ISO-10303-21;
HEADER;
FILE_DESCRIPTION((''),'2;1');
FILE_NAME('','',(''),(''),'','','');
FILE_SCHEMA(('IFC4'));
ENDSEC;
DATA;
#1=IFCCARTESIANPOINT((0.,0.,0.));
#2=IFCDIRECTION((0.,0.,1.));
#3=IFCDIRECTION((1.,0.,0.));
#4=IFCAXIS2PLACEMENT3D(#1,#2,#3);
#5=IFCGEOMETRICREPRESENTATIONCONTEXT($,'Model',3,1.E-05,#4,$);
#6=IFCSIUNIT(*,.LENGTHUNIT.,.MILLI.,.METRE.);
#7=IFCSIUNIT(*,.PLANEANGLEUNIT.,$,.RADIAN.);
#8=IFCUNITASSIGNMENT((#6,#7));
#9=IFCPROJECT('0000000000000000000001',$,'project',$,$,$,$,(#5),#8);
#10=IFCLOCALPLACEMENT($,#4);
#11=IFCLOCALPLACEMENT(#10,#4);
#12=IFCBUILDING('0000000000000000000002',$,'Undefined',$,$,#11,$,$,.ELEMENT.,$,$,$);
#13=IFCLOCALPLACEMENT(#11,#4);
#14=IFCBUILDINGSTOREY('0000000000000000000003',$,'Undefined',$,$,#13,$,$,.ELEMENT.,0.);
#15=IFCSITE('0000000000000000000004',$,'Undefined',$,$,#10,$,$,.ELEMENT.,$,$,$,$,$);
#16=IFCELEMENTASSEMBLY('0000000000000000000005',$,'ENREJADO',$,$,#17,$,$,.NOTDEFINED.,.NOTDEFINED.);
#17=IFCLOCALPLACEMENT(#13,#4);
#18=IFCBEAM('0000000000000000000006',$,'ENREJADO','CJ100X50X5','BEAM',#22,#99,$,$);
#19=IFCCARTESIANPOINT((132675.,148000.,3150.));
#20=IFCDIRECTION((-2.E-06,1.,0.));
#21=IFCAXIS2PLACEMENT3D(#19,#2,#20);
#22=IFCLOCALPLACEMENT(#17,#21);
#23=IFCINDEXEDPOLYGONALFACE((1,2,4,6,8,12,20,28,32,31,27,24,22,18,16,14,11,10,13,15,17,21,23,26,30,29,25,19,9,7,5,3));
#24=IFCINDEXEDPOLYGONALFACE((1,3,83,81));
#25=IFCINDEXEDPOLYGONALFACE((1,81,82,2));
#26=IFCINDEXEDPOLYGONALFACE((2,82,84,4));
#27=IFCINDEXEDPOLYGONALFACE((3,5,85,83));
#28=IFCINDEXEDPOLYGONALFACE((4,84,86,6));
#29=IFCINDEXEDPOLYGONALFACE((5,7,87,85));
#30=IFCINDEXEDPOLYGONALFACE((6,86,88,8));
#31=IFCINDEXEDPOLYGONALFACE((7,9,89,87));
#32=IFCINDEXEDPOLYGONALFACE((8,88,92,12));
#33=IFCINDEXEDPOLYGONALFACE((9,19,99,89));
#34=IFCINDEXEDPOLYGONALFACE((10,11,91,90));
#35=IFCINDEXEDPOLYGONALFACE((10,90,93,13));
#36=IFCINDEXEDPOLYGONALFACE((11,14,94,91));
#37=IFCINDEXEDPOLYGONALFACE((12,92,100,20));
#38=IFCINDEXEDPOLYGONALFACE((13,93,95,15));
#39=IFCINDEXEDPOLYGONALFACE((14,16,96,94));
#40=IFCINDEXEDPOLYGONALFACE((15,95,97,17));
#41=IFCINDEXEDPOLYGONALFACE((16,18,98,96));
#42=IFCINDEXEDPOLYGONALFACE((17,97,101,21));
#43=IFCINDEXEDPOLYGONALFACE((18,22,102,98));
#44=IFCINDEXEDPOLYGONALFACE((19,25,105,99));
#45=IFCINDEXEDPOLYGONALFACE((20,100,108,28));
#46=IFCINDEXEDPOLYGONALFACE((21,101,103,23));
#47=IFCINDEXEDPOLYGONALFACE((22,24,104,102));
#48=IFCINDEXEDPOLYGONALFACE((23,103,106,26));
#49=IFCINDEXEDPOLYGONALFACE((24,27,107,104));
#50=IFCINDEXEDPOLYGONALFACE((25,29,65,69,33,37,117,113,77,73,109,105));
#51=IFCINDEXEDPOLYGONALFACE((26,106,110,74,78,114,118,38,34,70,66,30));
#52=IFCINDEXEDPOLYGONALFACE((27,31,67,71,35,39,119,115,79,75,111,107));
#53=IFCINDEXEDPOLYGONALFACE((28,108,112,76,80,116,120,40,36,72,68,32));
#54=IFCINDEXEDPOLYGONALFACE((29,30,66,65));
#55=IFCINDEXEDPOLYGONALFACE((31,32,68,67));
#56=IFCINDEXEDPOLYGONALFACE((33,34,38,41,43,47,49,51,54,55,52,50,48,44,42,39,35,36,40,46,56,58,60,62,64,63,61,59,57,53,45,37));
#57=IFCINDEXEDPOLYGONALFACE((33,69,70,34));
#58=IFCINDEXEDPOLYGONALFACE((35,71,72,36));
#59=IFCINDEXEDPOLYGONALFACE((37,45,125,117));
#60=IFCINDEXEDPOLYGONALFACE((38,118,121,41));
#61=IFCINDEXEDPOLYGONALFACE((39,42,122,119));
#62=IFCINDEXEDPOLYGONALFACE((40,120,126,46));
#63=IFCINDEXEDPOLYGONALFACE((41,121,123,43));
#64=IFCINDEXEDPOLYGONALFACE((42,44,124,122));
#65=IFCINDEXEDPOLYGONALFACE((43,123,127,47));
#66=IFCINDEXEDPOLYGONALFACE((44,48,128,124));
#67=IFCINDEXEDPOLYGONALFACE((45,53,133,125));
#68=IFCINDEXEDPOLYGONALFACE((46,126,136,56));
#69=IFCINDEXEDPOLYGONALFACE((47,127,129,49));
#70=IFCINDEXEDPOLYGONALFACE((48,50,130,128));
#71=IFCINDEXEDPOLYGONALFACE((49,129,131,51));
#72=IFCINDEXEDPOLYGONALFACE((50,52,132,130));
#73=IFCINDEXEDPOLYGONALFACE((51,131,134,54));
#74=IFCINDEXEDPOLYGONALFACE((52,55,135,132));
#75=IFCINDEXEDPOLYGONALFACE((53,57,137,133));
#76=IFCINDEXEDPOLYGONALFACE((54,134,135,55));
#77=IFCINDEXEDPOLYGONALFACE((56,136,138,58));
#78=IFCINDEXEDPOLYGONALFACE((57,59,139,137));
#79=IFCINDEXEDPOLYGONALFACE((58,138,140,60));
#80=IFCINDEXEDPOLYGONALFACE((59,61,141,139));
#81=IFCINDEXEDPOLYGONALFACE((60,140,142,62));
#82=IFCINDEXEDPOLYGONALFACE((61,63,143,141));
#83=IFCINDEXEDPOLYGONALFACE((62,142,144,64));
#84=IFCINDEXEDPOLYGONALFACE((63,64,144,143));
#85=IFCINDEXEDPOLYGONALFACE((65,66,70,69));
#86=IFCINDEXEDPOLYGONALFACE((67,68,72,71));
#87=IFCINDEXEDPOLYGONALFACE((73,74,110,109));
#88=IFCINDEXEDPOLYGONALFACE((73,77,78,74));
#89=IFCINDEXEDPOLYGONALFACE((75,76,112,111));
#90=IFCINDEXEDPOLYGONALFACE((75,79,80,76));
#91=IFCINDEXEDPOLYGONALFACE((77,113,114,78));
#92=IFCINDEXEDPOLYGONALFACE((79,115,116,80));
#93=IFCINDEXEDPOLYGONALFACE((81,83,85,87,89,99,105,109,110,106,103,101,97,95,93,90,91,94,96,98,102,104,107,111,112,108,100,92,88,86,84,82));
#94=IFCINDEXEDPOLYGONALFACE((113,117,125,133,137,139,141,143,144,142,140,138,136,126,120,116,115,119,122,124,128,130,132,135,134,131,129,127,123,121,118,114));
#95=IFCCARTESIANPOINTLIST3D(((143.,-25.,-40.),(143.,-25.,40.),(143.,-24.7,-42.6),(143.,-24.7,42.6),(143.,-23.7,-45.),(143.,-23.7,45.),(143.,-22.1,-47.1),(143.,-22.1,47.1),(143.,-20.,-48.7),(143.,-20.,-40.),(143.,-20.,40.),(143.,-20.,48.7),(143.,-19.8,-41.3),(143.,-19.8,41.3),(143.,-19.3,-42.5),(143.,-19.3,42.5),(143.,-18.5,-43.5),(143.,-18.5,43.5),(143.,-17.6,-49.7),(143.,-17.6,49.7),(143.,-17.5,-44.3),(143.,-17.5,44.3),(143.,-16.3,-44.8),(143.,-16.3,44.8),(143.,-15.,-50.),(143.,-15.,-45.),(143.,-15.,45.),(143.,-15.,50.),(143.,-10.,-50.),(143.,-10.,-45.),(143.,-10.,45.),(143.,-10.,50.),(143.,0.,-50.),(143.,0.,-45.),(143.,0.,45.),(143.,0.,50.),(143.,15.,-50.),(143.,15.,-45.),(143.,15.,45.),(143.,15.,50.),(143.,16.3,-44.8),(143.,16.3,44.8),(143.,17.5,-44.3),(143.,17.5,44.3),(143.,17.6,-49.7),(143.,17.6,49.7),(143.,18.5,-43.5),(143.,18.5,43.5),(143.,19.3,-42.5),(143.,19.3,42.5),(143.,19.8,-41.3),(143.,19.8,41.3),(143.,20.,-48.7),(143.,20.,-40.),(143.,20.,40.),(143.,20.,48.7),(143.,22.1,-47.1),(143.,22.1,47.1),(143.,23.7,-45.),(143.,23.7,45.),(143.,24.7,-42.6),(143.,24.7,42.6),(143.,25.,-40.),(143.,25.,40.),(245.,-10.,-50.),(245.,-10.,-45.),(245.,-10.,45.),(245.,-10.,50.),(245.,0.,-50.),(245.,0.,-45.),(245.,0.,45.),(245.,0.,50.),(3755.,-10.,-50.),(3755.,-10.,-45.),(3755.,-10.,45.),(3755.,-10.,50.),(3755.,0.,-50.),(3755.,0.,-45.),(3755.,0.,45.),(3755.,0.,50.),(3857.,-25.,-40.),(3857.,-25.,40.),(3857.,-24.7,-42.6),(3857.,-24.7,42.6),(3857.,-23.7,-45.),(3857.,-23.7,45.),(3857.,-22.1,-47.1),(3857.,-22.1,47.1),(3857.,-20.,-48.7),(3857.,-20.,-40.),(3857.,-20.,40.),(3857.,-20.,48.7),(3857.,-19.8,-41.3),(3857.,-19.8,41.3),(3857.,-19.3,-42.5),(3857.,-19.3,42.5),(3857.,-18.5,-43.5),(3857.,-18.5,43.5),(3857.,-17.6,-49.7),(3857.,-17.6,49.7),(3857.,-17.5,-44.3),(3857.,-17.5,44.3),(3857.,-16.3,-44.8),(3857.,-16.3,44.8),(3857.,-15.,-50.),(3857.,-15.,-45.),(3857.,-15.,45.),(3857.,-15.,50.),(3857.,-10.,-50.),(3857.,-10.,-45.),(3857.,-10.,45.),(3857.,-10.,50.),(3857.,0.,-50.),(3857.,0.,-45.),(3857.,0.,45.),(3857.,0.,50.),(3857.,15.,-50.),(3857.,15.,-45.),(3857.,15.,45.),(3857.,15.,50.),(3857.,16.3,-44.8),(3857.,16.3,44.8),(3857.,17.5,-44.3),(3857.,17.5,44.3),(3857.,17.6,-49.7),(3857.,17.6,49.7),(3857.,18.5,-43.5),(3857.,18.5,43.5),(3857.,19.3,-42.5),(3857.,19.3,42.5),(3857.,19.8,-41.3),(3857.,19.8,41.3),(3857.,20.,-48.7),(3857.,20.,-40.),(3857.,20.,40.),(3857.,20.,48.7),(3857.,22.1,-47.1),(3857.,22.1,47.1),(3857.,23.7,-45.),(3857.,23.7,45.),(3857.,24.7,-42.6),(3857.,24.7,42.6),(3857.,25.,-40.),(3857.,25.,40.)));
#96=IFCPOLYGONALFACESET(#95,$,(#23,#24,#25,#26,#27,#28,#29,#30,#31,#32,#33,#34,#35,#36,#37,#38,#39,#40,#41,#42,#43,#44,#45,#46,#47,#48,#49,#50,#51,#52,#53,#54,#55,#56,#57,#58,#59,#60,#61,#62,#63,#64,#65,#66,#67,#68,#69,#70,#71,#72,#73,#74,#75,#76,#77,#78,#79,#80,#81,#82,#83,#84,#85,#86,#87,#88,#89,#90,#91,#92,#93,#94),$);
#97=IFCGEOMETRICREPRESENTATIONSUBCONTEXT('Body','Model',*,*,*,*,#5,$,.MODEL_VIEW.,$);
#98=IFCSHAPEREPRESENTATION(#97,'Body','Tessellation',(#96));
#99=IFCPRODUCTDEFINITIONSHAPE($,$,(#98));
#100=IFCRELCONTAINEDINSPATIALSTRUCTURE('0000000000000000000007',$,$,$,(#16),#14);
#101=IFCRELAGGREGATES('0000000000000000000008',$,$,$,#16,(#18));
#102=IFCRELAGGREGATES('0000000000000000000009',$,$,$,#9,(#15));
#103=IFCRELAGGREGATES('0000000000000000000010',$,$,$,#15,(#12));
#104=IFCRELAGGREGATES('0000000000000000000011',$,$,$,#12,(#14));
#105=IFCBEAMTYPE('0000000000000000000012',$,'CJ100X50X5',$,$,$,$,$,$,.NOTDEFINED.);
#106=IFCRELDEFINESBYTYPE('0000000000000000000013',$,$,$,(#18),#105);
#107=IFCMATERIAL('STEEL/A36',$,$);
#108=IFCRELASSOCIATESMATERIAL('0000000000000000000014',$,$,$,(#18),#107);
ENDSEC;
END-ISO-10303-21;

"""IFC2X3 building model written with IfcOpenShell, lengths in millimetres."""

from ifc_helpers import new_model, si_unit, frame, origin_with_axes, origin_2d_with_axis, place, context, subcontext, project, spatial, rectangle, hollow_rectangle, extrude, boolean, halfspace, material, type_object, element, aggregate, save


model = new_model("IFC2X3")

# Units and contexts
model_context = context("Model", 3, precision=1e-05, world=origin_with_axes())
body_context = subcontext(model_context, "Body", "Model", "MODEL_VIEW")
ifc_project = project(units=[si_unit("LENGTHUNIT", "METRE", prefix="MILLI"), si_unit("PLANEANGLEUNIT", "RADIAN")], contexts=[model_context])

# Site, building, storey
site_placement = place(None, origin_with_axes())
site = spatial("IfcSite", under=ifc_project, at=site_placement, Name="Undefined", CompositionType="ELEMENT")
building_placement = place(site_placement, origin_with_axes())
building = spatial("IfcBuilding", under=site, at=building_placement, Name="Undefined", CompositionType="ELEMENT")
storey_placement = place(building_placement, origin_with_axes())
storey = spatial("IfcBuildingStorey", under=building, at=storey_placement, Name="Undefined", CompositionType="ELEMENT", Elevation=0.0)

# Shared definitions
ifc_material_1 = material(Name="STEEL/A36")

# Shared definitions
beam_type_1 = type_object("IfcBeamType", Name="CJ100X50X5", PredefinedType="NOTDEFINED")

# Element assembly, beam
assembly_1_placement = place(storey_placement, origin_with_axes())
assembly_1 = element("IfcElementAssembly", 1, at=assembly_1_placement, inside=storey, Name="ENREJADO", AssemblyPlace="NOTDEFINED", PredefinedType="NOTDEFINED")
beam_1_placement = place(assembly_1_placement, frame((132675.0, 148000.0, 3150.0), z_axis=(0.0, 0.0, 1.0), x_axis=(-0.000002, 1.0, 0.0)))
beam_1 = element("IfcBeam", 2, at=beam_1_placement, type_object=beam_type_1, material=ifc_material_1, Name="ENREJADO", Description="CJ100X50X5", ObjectType="BEAM", context=body_context, shape_type="CSG", body=[
    boolean("DIFFERENCE", boolean("DIFFERENCE", boolean("DIFFERENCE", boolean("DIFFERENCE", extrude(hollow_rectangle(XDim=50.0, YDim=100.0, WallThickness=5.0, InnerFilletRadius=5.0, OuterFilletRadius=10.0, at=origin_2d_with_axis()), frame((4000.0, 0.0, 0.0), z_axis=(-1.0, 0.0, 0.0), x_axis=(0.0, -1.0, 0.0)), (0.0, 0.0, 1.0), 4000.0), extrude(rectangle(XDim=10.0, YDim=104.0, at=origin_2d_with_axis()), frame((3755.0, -5.0, 0.0), z_axis=(1.0, 0.0, 0.0), x_axis=(0.0, 1.0, 0.0)), (0.0, 0.0, 1.0), 120.0)), extrude(rectangle(XDim=10.0, YDim=104.0, at=origin_2d_with_axis()), frame((245.0, -5.0, 0.0), z_axis=(-1.0, 0.000003, 0.0), x_axis=(0.000002, 1.0, 0.0)), (0.0, 0.0, 1.0), 120.0)), halfspace(frame((3857.0, 200.0, 50.0), z_axis=(-1.0, 0.0, 0.0), x_axis=(0.0, -1.0, 0.0)), True)), halfspace(frame((143.0, 200.0, -50.0), z_axis=(1.0, -0.000003, 0.0), x_axis=(-0.000002, -1.0, 0.0)), True)),
])

aggregate(assembly_1, [beam_1])

save(model, "model.ifc")
